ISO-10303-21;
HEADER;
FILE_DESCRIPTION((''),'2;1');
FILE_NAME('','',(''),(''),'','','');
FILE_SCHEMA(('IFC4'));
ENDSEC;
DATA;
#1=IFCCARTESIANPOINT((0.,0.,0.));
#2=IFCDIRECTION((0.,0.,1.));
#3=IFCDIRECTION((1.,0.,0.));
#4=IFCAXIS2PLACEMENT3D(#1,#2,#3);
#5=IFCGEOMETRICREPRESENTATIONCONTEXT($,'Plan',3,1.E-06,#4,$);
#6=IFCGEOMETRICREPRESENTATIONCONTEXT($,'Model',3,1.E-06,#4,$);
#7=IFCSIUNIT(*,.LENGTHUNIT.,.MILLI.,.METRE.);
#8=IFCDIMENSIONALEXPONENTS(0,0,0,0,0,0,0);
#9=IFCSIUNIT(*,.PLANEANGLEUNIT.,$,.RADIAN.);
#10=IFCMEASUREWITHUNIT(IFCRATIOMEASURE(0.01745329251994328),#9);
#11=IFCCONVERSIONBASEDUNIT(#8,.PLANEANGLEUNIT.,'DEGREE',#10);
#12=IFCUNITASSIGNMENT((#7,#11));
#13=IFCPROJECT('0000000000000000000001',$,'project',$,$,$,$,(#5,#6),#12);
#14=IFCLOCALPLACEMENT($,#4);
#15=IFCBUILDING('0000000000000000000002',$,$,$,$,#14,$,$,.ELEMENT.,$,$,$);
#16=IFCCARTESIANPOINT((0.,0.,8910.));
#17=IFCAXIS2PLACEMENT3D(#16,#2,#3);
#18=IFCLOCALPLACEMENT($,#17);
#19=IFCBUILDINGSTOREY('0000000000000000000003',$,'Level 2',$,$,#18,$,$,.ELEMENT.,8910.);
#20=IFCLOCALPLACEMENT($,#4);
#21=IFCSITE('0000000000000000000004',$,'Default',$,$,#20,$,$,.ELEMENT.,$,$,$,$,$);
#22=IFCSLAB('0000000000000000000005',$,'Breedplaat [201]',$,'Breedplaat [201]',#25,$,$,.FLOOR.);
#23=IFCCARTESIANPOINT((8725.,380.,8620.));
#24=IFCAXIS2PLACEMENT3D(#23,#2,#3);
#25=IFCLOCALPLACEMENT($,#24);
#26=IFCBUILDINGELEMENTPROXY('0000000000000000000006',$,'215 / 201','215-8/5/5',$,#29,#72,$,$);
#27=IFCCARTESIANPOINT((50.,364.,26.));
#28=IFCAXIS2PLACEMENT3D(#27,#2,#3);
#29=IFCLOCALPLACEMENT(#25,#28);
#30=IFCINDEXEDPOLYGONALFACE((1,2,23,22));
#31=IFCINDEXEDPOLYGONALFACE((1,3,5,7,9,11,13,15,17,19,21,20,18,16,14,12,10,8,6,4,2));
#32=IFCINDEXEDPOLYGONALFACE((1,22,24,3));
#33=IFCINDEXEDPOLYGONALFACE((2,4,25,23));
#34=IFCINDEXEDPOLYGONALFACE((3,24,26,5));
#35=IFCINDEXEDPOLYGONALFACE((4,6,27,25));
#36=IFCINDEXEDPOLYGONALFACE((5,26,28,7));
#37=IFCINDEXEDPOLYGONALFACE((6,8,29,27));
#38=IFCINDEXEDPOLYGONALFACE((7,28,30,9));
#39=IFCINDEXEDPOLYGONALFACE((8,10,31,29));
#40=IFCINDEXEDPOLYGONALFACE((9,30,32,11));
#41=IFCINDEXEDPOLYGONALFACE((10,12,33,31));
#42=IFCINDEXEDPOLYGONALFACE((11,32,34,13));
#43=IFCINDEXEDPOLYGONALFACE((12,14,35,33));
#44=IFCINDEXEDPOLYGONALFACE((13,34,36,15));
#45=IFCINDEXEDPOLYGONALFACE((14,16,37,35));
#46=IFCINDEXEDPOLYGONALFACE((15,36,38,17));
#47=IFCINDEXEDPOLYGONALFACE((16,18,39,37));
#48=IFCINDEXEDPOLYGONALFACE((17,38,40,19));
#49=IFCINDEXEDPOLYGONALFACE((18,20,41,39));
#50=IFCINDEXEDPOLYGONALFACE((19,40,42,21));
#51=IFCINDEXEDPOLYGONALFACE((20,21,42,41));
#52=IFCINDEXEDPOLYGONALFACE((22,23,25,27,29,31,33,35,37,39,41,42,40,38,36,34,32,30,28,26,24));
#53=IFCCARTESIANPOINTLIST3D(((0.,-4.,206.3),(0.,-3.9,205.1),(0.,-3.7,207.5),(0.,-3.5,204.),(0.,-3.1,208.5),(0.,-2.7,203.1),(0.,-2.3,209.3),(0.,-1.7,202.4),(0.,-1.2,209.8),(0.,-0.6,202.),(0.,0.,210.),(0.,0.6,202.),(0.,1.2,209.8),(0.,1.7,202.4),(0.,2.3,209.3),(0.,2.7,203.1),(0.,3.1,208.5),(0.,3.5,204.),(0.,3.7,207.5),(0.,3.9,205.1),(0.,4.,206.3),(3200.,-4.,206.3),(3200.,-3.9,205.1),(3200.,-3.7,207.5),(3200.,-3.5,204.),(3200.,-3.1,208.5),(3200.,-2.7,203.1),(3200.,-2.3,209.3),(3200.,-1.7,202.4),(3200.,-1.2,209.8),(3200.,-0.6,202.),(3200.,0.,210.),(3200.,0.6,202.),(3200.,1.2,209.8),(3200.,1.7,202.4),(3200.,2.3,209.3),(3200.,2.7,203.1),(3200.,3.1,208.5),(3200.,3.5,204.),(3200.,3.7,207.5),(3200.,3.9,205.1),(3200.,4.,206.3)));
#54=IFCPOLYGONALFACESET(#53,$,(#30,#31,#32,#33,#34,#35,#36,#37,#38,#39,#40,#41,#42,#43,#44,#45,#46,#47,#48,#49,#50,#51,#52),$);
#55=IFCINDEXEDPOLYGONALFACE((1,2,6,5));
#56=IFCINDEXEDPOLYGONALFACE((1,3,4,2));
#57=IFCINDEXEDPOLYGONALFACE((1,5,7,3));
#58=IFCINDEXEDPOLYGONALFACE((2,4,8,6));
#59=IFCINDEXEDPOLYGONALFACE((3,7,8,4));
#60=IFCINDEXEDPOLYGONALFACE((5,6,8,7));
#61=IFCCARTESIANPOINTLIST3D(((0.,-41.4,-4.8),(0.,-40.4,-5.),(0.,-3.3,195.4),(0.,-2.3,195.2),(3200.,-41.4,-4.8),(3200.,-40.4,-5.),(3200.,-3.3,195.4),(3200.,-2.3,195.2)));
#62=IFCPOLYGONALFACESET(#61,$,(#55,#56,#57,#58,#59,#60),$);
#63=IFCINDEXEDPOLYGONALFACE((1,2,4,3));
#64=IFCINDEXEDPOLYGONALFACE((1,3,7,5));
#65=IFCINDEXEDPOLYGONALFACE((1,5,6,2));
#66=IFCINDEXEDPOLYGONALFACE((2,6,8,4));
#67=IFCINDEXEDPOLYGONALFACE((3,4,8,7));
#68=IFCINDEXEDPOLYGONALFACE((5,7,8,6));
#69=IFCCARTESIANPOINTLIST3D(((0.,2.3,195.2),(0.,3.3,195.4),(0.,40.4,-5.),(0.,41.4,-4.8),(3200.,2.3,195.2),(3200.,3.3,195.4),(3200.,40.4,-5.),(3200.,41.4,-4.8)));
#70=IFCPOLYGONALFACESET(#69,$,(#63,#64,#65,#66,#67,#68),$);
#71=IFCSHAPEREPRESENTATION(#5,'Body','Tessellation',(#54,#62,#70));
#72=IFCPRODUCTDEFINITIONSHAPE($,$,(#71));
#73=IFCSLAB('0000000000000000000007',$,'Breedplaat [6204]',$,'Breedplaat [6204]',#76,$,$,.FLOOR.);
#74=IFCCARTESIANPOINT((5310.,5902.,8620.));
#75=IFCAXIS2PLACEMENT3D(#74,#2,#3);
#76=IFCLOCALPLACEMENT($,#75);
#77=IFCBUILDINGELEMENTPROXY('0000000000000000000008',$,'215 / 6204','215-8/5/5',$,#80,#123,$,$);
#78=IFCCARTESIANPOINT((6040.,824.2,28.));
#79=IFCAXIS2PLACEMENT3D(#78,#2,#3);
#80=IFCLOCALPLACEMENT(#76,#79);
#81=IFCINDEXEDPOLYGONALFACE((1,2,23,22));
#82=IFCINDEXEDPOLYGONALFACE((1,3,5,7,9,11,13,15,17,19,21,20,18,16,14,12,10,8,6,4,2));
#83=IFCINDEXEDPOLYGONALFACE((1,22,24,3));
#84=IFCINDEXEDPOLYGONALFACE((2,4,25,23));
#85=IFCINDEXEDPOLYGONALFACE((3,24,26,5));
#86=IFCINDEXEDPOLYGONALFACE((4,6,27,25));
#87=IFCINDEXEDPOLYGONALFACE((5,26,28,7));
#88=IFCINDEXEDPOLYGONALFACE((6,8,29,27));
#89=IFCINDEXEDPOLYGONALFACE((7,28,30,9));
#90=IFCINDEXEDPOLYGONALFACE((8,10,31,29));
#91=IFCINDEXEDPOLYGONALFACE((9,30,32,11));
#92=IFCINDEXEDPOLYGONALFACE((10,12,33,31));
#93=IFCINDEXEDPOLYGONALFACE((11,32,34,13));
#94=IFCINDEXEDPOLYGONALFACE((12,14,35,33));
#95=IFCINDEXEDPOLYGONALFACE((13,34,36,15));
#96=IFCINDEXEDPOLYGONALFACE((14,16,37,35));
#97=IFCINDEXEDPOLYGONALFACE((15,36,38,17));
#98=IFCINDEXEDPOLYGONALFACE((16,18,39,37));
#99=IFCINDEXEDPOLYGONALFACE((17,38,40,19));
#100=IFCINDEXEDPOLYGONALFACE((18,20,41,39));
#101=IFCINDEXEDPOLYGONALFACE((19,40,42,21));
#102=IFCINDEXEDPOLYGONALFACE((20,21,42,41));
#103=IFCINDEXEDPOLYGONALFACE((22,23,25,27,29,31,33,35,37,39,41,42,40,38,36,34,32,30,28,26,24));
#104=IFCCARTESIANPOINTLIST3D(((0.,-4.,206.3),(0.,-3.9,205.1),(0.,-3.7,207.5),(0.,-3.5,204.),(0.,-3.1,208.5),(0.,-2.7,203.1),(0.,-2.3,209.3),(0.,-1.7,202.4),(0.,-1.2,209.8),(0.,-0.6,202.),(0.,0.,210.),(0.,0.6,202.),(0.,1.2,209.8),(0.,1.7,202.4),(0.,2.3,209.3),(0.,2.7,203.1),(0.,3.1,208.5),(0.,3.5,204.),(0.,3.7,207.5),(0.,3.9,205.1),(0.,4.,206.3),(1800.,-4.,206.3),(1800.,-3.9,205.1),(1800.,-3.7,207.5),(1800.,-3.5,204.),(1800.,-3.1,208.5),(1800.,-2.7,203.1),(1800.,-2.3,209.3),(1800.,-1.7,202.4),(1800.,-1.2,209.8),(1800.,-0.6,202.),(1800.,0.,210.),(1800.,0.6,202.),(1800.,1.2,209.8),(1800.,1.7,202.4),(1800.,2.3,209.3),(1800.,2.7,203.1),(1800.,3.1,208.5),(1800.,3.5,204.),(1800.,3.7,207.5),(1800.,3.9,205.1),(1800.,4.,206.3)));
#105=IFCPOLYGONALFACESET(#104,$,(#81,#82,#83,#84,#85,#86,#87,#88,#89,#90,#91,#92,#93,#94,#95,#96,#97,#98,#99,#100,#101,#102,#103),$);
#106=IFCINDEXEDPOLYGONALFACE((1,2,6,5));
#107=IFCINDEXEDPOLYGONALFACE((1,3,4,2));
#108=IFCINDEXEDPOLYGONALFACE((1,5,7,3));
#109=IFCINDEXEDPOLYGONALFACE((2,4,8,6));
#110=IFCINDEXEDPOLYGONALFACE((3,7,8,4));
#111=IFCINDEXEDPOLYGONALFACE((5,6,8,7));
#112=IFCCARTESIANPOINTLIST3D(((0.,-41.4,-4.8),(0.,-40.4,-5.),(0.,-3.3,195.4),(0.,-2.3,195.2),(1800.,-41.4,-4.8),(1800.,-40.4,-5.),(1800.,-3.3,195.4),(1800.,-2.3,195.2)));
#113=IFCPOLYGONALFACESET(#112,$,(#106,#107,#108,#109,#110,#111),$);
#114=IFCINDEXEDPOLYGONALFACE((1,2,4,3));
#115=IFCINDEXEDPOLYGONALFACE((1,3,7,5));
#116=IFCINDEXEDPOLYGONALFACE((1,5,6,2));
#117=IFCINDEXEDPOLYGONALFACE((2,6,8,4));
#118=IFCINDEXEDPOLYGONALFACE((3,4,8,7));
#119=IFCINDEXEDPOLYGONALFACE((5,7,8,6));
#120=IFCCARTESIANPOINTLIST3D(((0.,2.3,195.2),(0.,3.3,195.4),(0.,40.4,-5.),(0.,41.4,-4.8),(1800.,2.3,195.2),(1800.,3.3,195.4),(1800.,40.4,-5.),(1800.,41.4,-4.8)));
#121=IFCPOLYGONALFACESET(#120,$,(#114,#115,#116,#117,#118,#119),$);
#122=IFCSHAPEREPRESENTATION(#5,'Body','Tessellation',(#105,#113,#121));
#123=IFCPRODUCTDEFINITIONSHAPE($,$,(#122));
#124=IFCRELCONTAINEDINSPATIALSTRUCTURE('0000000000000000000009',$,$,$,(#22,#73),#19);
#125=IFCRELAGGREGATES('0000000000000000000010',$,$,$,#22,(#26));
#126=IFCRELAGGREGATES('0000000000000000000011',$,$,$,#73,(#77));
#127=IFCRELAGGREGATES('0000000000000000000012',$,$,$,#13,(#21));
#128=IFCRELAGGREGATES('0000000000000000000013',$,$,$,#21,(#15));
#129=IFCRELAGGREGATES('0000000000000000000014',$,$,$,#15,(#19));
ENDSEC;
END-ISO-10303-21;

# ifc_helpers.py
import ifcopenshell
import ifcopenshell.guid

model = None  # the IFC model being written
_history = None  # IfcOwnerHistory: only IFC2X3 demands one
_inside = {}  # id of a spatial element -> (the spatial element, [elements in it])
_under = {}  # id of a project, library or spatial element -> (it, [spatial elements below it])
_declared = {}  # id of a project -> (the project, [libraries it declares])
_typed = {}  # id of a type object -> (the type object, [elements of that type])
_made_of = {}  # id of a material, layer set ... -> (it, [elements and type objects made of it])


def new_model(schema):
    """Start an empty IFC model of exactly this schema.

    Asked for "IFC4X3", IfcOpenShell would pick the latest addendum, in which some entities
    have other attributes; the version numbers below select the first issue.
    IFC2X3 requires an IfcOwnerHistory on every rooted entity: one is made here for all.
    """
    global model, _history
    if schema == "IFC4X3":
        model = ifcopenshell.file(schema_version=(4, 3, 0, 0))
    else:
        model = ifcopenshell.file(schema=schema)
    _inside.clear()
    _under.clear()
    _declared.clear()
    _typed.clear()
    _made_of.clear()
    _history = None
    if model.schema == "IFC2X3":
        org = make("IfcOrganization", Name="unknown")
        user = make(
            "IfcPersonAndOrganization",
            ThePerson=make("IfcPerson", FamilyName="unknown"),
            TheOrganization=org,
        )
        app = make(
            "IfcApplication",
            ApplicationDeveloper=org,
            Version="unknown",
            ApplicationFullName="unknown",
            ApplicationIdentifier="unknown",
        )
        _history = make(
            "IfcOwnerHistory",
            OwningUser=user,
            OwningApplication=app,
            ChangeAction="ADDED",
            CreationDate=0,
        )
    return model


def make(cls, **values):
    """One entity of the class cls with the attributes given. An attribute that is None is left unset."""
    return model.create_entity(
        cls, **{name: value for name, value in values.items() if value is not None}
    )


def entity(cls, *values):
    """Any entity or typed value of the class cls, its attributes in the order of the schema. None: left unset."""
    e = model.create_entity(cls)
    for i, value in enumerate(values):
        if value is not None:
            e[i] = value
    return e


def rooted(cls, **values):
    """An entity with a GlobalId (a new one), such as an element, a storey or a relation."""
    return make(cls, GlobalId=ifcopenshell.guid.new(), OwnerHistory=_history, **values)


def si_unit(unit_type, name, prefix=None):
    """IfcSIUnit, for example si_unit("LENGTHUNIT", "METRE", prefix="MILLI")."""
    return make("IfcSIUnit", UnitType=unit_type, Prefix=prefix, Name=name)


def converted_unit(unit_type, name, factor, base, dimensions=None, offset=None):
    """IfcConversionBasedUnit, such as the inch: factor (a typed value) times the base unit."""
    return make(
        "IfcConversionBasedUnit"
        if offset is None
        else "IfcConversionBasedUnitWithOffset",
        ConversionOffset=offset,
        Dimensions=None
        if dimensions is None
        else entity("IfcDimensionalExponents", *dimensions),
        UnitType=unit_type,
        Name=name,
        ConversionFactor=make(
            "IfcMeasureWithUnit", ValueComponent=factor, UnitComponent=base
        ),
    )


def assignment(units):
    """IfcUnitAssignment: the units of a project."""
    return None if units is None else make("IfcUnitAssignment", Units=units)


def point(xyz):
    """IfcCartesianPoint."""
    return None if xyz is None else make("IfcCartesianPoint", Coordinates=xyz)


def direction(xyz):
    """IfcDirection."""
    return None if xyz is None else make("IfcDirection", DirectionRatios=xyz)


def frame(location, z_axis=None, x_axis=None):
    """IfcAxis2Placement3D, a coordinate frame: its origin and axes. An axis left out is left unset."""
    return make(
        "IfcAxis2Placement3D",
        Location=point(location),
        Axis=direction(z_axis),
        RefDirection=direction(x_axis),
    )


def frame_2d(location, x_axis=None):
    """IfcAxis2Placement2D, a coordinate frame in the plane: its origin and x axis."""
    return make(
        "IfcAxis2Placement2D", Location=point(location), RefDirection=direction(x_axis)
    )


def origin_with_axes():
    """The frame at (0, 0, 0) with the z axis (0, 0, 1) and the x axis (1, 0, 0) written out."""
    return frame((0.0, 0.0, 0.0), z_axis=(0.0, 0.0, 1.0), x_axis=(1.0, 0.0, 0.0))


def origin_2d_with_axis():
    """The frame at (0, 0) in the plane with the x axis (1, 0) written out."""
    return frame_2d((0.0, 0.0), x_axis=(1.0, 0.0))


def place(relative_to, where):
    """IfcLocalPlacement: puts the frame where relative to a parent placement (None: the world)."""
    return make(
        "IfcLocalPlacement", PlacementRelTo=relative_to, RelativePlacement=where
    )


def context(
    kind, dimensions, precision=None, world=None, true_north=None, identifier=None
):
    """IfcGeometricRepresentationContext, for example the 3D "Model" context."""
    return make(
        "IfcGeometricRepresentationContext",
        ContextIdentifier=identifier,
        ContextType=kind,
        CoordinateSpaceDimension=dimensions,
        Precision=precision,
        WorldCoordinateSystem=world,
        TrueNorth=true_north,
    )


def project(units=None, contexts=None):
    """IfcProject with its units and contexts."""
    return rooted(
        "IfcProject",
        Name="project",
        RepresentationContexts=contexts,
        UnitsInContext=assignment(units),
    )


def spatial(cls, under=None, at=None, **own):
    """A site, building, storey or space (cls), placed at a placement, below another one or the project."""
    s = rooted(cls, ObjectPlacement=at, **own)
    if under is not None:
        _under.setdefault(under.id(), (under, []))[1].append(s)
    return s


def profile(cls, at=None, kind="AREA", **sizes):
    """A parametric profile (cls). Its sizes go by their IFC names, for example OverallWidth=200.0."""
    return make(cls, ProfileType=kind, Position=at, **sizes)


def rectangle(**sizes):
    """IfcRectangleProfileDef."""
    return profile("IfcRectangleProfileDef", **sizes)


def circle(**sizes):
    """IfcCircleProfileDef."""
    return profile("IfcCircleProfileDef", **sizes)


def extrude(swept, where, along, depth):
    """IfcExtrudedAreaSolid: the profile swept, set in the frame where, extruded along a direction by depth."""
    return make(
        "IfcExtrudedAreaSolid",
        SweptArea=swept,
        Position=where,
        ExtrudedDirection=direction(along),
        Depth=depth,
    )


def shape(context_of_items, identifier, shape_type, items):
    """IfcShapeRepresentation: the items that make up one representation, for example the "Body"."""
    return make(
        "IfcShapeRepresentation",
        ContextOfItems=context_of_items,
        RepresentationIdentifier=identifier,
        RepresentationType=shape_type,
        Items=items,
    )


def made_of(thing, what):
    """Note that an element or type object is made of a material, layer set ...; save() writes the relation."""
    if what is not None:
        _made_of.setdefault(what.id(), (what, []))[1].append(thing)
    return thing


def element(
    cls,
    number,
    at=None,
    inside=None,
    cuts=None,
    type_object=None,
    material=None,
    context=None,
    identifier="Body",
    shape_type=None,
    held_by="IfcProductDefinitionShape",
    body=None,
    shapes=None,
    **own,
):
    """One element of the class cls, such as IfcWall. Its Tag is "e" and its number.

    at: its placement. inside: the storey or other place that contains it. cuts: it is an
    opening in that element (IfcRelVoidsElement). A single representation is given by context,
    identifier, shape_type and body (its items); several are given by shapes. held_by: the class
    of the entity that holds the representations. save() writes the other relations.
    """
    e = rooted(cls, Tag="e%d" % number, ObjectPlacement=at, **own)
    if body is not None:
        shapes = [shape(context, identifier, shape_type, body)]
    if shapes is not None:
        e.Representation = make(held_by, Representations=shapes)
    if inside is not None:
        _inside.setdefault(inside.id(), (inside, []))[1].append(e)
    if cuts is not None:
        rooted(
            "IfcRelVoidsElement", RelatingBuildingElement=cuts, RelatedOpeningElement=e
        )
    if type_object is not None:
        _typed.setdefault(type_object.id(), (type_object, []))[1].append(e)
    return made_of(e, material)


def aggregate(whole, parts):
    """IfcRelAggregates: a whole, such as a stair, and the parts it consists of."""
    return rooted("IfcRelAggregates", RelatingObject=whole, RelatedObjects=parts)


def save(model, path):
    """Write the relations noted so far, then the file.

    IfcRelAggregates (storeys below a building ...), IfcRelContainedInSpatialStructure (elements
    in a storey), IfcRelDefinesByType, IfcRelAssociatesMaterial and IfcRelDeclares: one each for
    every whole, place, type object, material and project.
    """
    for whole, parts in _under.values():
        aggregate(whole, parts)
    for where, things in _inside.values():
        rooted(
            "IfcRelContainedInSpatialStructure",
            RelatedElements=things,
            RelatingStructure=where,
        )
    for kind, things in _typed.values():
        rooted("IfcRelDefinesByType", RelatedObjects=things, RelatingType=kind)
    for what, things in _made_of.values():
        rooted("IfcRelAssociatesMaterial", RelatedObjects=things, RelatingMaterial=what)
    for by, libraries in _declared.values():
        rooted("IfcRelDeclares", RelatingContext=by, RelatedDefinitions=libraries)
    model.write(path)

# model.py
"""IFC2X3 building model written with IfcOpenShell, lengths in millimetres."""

from ifc_helpers import new_model, entity, si_unit, converted_unit, frame, origin_with_axes, origin_2d_with_axis, place, context, project, spatial, rectangle, circle, extrude, element, aggregate, save


model = new_model("IFC2X3")

# Units and contexts
plan_context = context("Plan", 3, precision=1e-06, world=origin_with_axes())
model_context = context("Model", 3, precision=1e-06, world=origin_with_axes())
ifc_project = project(units=[si_unit("LENGTHUNIT", "METRE", prefix="MILLI"), converted_unit("PLANEANGLEUNIT", "DEGREE", entity("IfcRatioMeasure", 0.01745329251994328), si_unit("PLANEANGLEUNIT", "RADIAN"), dimensions=[0, 0, 0, 0, 0, 0, 0])], contexts=[plan_context, model_context])

# Site, building, storey
site_placement = place(None, origin_with_axes())
site = spatial("IfcSite", under=ifc_project, at=site_placement, Name="Default", CompositionType="ELEMENT")
building_placement = place(None, origin_with_axes())
building = spatial("IfcBuilding", under=site, at=building_placement, CompositionType="ELEMENT")
storey_placement = place(None, frame((0.0, 0.0, 8910.0), z_axis=(0.0, 0.0, 1.0), x_axis=(1.0, 0.0, 0.0)))
storey = spatial("IfcBuildingStorey", under=building, at=storey_placement, Name="Level 2", CompositionType="ELEMENT", Elevation=8910.0)

# Slab, building element proxy
slab_1_placement = place(None, frame((8725.0, 380.0, 8620.0), z_axis=(0.0, 0.0, 1.0), x_axis=(1.0, 0.0, 0.0)))
slab_1 = element("IfcSlab", 1, at=slab_1_placement, inside=storey, Name="Breedplaat [201]", ObjectType="Breedplaat [201]", PredefinedType="FLOOR")
proxy_1_placement = place(slab_1_placement, frame((50.0, 364.0, 26.0), z_axis=(0.0, 0.0, 1.0), x_axis=(1.0, 0.0, 0.0)))
proxy_1 = element("IfcBuildingElementProxy", 2, at=proxy_1_placement, Name="215 / 201", Description="215-8/5/5", context=plan_context, shape_type="SweptSolid", body=[
    extrude(circle(Radius=4.0, at=origin_2d_with_axis()), frame((0.0, 0.0, 206.0), z_axis=(1.0, 0.0, 0.0), x_axis=(0.0, 0.0, 1.0)), (0.0, 0.0, 1.0), 3200.0),
    extrude(rectangle(XDim=203.8, YDim=1.0, at=origin_2d_with_axis()), frame((0.0, -21.9, 95.2), z_axis=(1.0, 0.0, 0.0), x_axis=(0.0, 0.187112, 0.982339)), (0.0, 0.0, 1.0), 3200.0),
    extrude(rectangle(XDim=203.8, YDim=1.0, at=origin_2d_with_axis()), frame((0.0, 21.9, 95.2), z_axis=(1.0, 0.0, 0.0), x_axis=(0.0, -0.187112, 0.982339)), (0.0, 0.0, 1.0), 3200.0),
])
aggregate(slab_1, [proxy_1])

# Slab, building element proxy
slab_2_placement = place(None, frame((5310.0, 5902.0, 8620.0), z_axis=(0.0, 0.0, 1.0), x_axis=(1.0, 0.0, 0.0)))
slab_2 = element("IfcSlab", 3, at=slab_2_placement, inside=storey, Name="Breedplaat [6204]", ObjectType="Breedplaat [6204]", PredefinedType="FLOOR")
proxy_2_placement = place(slab_2_placement, frame((6040.0, 824.2, 28.0), z_axis=(0.0, 0.0, 1.0), x_axis=(1.0, 0.0, 0.0)))
proxy_2 = element("IfcBuildingElementProxy", 4, at=proxy_2_placement, Name="215 / 6204", Description="215-8/5/5", context=plan_context, shape_type="SweptSolid", body=[
    extrude(circle(Radius=4.0, at=origin_2d_with_axis()), frame((0.0, 0.0, 206.0), z_axis=(1.0, 0.0, 0.0), x_axis=(0.0, 0.0, 1.0)), (0.0, 0.0, 1.0), 1800.0),
    extrude(rectangle(XDim=203.8, YDim=1.0, at=origin_2d_with_axis()), frame((0.0, -21.9, 95.2), z_axis=(1.0, 0.0, 0.0), x_axis=(0.0, 0.187112, 0.982339)), (0.0, 0.0, 1.0), 1800.0),
    extrude(rectangle(XDim=203.8, YDim=1.0, at=origin_2d_with_axis()), frame((0.0, 21.9, 95.2), z_axis=(1.0, 0.0, 0.0), x_axis=(0.0, -0.187112, 0.982339)), (0.0, 0.0, 1.0), 1800.0),
])
aggregate(slab_2, [proxy_2])

save(model, "model.ifc")
